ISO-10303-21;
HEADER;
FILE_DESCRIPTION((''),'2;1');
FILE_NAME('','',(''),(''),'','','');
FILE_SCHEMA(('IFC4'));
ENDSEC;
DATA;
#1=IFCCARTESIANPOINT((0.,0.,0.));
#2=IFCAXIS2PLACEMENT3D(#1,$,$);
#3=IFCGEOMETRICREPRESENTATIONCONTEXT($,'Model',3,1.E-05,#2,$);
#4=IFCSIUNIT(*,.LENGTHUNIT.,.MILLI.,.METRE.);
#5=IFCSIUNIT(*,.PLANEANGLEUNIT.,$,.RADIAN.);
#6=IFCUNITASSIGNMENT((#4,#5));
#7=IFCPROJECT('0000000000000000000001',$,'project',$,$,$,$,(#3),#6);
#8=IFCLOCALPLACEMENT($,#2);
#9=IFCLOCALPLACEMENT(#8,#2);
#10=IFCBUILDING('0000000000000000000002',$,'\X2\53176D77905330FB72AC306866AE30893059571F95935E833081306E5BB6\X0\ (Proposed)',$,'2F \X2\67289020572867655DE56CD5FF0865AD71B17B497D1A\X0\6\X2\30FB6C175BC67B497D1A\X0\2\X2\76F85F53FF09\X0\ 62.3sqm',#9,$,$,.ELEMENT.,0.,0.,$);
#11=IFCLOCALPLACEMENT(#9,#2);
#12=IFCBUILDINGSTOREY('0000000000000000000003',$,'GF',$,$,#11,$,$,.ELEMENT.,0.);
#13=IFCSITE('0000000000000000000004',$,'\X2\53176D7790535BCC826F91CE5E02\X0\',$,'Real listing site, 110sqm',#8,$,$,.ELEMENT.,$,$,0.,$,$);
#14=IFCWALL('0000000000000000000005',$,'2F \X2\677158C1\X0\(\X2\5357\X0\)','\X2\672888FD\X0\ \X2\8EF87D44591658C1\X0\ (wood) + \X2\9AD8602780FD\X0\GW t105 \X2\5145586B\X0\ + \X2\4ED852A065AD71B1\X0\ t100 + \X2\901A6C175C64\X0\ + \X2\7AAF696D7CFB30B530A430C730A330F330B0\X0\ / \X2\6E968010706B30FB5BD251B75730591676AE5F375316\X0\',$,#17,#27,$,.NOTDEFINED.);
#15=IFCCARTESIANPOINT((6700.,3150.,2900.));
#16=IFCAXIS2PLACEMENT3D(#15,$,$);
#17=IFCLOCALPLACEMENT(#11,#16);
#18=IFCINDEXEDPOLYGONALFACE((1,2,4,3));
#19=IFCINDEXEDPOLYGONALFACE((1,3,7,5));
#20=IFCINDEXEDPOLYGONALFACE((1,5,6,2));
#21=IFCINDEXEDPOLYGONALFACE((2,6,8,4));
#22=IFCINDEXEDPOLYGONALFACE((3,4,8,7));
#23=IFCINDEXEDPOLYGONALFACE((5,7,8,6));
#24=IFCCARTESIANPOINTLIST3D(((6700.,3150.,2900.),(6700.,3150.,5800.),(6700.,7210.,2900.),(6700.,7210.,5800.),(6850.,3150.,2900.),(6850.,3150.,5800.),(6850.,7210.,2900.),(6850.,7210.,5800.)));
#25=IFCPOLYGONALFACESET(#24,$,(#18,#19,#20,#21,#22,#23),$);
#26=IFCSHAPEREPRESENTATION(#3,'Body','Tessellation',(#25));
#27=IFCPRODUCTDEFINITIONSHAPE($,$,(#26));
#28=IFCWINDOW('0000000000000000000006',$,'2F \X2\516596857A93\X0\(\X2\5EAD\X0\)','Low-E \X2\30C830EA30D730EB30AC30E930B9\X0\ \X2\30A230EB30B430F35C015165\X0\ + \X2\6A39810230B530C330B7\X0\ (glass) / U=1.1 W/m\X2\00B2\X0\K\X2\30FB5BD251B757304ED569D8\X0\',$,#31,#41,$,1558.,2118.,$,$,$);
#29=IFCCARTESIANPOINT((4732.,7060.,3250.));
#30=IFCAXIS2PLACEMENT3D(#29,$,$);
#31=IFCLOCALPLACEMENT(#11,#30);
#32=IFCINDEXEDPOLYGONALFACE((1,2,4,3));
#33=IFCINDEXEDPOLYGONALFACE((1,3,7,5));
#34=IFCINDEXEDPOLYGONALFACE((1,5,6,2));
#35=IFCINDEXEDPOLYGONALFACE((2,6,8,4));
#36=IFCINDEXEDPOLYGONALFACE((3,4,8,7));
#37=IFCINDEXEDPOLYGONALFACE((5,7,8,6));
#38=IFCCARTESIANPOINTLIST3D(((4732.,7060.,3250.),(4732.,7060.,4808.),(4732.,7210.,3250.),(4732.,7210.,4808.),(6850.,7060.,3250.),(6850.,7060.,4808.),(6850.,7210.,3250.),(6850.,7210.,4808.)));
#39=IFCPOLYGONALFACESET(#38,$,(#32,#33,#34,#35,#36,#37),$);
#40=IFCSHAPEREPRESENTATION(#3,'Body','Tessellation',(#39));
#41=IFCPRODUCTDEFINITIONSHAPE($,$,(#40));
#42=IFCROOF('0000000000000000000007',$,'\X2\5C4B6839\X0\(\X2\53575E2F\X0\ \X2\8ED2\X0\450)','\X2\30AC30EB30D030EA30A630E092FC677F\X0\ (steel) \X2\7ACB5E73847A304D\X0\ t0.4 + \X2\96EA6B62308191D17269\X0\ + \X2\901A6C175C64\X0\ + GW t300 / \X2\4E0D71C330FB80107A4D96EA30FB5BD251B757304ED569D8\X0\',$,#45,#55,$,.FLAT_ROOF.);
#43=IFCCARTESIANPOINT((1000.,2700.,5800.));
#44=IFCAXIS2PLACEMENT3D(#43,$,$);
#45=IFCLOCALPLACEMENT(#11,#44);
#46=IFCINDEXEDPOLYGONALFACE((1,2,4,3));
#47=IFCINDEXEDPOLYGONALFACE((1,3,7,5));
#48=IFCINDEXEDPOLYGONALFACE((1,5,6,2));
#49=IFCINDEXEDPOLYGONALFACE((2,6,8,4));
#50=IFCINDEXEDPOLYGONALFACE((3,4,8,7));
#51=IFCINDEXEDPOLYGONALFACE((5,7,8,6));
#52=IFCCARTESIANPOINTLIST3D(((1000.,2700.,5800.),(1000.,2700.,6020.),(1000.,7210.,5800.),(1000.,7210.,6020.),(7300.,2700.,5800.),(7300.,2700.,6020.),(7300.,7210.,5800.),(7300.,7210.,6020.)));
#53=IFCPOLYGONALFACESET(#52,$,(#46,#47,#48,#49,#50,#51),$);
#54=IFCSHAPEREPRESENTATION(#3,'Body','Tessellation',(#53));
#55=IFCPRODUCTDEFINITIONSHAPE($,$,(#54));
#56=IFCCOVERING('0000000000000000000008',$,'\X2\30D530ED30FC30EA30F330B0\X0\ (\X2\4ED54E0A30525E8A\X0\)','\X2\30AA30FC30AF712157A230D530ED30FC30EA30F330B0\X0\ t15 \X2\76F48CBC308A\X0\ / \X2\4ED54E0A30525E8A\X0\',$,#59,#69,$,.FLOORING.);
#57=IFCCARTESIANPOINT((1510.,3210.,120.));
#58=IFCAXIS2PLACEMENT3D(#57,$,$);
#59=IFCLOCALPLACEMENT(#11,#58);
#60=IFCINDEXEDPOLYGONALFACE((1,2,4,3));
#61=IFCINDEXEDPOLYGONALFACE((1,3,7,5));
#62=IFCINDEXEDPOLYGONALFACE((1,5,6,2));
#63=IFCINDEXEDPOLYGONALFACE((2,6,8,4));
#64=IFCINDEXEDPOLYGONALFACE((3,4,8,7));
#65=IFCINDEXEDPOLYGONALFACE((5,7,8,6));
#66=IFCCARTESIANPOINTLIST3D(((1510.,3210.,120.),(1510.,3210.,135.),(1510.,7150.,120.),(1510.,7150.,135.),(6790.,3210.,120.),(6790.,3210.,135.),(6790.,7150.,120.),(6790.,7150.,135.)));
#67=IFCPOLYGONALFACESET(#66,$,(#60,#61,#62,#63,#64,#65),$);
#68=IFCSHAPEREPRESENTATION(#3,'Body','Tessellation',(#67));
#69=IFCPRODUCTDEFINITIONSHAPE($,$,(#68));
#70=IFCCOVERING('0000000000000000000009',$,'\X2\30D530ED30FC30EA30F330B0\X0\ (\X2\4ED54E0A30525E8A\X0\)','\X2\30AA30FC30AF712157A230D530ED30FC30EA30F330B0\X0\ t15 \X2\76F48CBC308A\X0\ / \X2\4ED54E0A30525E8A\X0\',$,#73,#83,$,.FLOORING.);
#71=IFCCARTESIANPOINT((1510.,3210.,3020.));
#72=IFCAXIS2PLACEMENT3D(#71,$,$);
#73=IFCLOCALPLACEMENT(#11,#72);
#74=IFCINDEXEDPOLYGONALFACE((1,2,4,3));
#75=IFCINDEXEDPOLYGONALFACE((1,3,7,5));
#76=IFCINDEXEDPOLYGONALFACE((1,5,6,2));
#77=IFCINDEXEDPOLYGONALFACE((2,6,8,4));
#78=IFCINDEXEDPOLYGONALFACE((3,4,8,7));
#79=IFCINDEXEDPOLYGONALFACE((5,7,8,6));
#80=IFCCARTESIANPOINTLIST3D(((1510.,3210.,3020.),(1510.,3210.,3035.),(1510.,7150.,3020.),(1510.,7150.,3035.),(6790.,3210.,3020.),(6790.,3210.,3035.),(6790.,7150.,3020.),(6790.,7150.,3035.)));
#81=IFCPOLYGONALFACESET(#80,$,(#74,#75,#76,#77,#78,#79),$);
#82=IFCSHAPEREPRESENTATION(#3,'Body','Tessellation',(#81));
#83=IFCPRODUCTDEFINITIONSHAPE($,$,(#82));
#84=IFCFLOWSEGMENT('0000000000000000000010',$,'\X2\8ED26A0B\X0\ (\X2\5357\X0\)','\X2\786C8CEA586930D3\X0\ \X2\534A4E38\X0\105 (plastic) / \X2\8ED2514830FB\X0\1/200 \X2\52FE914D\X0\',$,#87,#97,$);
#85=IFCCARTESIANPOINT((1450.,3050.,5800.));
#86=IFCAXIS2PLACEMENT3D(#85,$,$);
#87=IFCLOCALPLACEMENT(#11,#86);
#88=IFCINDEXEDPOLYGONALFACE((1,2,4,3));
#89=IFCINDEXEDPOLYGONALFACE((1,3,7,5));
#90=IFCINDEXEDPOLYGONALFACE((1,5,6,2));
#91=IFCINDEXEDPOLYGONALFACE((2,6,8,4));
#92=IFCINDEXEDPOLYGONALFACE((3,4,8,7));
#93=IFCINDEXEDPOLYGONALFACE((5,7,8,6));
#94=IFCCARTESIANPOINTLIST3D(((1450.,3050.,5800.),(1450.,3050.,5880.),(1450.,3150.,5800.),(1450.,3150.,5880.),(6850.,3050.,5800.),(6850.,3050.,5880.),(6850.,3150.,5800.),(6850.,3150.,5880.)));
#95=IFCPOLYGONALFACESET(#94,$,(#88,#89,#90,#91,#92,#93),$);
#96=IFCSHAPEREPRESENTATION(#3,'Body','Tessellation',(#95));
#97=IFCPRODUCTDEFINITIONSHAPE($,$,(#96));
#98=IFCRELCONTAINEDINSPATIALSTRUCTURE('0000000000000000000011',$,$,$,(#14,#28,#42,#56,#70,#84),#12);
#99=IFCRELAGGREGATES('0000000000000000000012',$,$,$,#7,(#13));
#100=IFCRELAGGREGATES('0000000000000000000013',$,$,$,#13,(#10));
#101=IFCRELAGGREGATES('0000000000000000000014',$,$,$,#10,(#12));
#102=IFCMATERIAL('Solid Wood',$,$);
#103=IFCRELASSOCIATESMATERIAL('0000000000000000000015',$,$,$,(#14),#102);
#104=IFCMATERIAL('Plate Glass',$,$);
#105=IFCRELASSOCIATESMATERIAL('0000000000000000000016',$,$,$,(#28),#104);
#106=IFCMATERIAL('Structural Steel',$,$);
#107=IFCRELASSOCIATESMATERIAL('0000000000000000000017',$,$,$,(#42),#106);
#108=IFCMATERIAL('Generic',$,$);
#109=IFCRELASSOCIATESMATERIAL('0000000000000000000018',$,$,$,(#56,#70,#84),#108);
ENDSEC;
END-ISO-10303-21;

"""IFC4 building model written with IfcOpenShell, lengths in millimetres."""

from ifc_helpers import new_model, si_unit, frame, frame_2d, origin, place, context, project, spatial, rectangle, extrude, material, element, fill, save


model = new_model("IFC4")

# Units and contexts
model_context = context("Model", 3, precision=1e-05, world=origin())
ifc_project = project(units=[si_unit("LENGTHUNIT", "METRE", prefix="MILLI"), si_unit("PLANEANGLEUNIT", "RADIAN")], contexts=[model_context])

# Site, building, storey
site_placement = place(None, origin())
site = spatial("IfcSite", under=ifc_project, at=site_placement, Name="北海道富良野市", ObjectType="Real listing site, 110sqm", CompositionType="ELEMENT", RefElevation=0.0)
building_placement = place(site_placement, origin())
building = spatial("IfcBuilding", under=site, at=building_placement, Name="北海道・犬と暮らす土間広めの家 (Proposed)", ObjectType="2F 木造在来工法（断熱等級6・気密等級2相当） 62.3sqm", CompositionType="ELEMENT", ElevationOfRefHeight=0.0, ElevationOfTerrain=0.0)
storey_placement = place(building_placement, origin())
storey = spatial("IfcBuildingStorey", under=building, at=storey_placement, Name="GF", CompositionType="ELEMENT", Elevation=0.0)

# Shared definitions
ifc_material_1 = material(Name="Solid Wood")

# Shared definitions
ifc_material_2 = material(Name="Plate Glass")

# Wall, opening, window
wall_1_placement = place(storey_placement, frame((6700.0, 3150.0, 2900.0)))
wall_1 = element("IfcWall", 1, at=wall_1_placement, inside=storey, material=ifc_material_1, Name="2F 東壁(南)", Description="木製 軸組外壁 (wood) + 高性能GW t105 充填 + 付加断熱 t100 + 通気層 + 窯業系サイディング / 準耐火・寒冷地外皮強化", PredefinedType="NOTDEFINED", context=model_context, shape_type="SweptSolid", body=[
    extrude(rectangle(XDim=150.0, YDim=4060.0, at=frame_2d((75.0, 2030.0))), frame((6700.0, 3150.0, 2900.0)), (0.0, 0.0, 1.0), 2900.0),
])
opening_1_placement = place(storey_placement, frame((4732.0, 7060.0, 3250.0)))
opening_1 = element("IfcOpeningElement", 2, at=opening_1_placement, cuts=wall_1, PredefinedType="NOTDEFINED", context=model_context, shape_type="SweptSolid", body=[
    extrude(rectangle(XDim=2118.0, YDim=150.0, at=frame_2d((1059.0, 75.0))), frame((4732.0, 7060.0, 3250.0)), (0.0, 0.0, 1.0), 1558.0),
])
window_1_placement = place(storey_placement, frame((4732.0, 7060.0, 3250.0)))
window_1 = element("IfcWindow", 3, at=window_1_placement, inside=storey, material=ifc_material_2, Name="2F 入隅窓(庭)", Description="Low-E トリプルガラス アルゴン封入 + 樹脂サッシ (glass) / U=1.1 W/m²K・寒冷地仕様", OverallHeight=1558.0, OverallWidth=2118.0, context=model_context, shape_type="SweptSolid", body=[
    extrude(rectangle(XDim=2118.0, YDim=150.0, at=frame_2d((1059.0, 75.0))), frame((4732.0, 7060.0, 3250.0)), (0.0, 0.0, 1.0), 1558.0),
])
fill(opening_1, window_1)

# Roof
ifc_material_3 = material(Name="Structural Steel")
for number, where, name in (
    (4, (1000.0, 2700.0, 5800.0), "屋根(南帯 軒450)"),
):
    element("IfcRoof", number, at=place(storey_placement, frame(where)), inside=storey, material=ifc_material_3, Name=name, Description="ガルバリウム鋼板 (steel) 立平葺き t0.4 + 雪止め金物 + 通気層 + GW t300 / 不燃・耐積雪・寒冷地仕様", PredefinedType="FLAT_ROOF", context=model_context, shape_type="SweptSolid", body=[
        extrude(rectangle(XDim=6300.0, YDim=4510.0, at=frame_2d((3150.0, 2255.0))), frame((1000.0, 2700.0, 5800.0)), (0.0, 0.0, 1.0), 220.0),
    ])

# Coverings
ifc_material_4 = material(Name="Generic")
covering_1_placement = place(storey_placement, frame((1510.0, 3210.0, 120.0)))
element("IfcCovering", 5, at=covering_1_placement, inside=storey, material=ifc_material_4, Name="フローリング (仕上げ床)", Description="オーク無垢フローリング t15 直貼り / 仕上げ床", PredefinedType="FLOORING", context=model_context, shape_type="SweptSolid", body=[
    extrude(rectangle(XDim=5280.0, YDim=3940.0, at=frame_2d((2640.0, 1970.0))), frame((1510.0, 3210.0, 120.0)), (0.0, 0.0, 1.0), 15.0),
])
covering_2_placement = place(storey_placement, frame((1510.0, 3210.0, 3020.0)))
element("IfcCovering", 6, at=covering_2_placement, inside=storey, material=ifc_material_4, Name="フローリング (仕上げ床)", Description="オーク無垢フローリング t15 直貼り / 仕上げ床", PredefinedType="FLOORING", context=model_context, shape_type="SweptSolid", body=[
    extrude(rectangle(XDim=5280.0, YDim=3940.0, at=frame_2d((2640.0, 1970.0))), frame((1510.0, 3210.0, 3020.0)), (0.0, 0.0, 1.0), 15.0),
])

# Flow segment
flow_segment_placement = place(storey_placement, frame((1450.0, 3050.0, 5800.0)))
element("IfcFlowSegment", 7, at=flow_segment_placement, inside=storey, material=ifc_material_4, Name="軒樋 (南)", Description="硬質塩ビ 半丸105 (plastic) / 軒先・1/200 勾配", context=model_context, shape_type="SweptSolid", body=[
    extrude(rectangle(XDim=5400.0, YDim=100.0, at=frame_2d((2700.0, 50.0))), frame((1450.0, 3050.0, 5800.0)), (0.0, 0.0, 1.0), 80.0),
])

save(model, "model.ifc")
